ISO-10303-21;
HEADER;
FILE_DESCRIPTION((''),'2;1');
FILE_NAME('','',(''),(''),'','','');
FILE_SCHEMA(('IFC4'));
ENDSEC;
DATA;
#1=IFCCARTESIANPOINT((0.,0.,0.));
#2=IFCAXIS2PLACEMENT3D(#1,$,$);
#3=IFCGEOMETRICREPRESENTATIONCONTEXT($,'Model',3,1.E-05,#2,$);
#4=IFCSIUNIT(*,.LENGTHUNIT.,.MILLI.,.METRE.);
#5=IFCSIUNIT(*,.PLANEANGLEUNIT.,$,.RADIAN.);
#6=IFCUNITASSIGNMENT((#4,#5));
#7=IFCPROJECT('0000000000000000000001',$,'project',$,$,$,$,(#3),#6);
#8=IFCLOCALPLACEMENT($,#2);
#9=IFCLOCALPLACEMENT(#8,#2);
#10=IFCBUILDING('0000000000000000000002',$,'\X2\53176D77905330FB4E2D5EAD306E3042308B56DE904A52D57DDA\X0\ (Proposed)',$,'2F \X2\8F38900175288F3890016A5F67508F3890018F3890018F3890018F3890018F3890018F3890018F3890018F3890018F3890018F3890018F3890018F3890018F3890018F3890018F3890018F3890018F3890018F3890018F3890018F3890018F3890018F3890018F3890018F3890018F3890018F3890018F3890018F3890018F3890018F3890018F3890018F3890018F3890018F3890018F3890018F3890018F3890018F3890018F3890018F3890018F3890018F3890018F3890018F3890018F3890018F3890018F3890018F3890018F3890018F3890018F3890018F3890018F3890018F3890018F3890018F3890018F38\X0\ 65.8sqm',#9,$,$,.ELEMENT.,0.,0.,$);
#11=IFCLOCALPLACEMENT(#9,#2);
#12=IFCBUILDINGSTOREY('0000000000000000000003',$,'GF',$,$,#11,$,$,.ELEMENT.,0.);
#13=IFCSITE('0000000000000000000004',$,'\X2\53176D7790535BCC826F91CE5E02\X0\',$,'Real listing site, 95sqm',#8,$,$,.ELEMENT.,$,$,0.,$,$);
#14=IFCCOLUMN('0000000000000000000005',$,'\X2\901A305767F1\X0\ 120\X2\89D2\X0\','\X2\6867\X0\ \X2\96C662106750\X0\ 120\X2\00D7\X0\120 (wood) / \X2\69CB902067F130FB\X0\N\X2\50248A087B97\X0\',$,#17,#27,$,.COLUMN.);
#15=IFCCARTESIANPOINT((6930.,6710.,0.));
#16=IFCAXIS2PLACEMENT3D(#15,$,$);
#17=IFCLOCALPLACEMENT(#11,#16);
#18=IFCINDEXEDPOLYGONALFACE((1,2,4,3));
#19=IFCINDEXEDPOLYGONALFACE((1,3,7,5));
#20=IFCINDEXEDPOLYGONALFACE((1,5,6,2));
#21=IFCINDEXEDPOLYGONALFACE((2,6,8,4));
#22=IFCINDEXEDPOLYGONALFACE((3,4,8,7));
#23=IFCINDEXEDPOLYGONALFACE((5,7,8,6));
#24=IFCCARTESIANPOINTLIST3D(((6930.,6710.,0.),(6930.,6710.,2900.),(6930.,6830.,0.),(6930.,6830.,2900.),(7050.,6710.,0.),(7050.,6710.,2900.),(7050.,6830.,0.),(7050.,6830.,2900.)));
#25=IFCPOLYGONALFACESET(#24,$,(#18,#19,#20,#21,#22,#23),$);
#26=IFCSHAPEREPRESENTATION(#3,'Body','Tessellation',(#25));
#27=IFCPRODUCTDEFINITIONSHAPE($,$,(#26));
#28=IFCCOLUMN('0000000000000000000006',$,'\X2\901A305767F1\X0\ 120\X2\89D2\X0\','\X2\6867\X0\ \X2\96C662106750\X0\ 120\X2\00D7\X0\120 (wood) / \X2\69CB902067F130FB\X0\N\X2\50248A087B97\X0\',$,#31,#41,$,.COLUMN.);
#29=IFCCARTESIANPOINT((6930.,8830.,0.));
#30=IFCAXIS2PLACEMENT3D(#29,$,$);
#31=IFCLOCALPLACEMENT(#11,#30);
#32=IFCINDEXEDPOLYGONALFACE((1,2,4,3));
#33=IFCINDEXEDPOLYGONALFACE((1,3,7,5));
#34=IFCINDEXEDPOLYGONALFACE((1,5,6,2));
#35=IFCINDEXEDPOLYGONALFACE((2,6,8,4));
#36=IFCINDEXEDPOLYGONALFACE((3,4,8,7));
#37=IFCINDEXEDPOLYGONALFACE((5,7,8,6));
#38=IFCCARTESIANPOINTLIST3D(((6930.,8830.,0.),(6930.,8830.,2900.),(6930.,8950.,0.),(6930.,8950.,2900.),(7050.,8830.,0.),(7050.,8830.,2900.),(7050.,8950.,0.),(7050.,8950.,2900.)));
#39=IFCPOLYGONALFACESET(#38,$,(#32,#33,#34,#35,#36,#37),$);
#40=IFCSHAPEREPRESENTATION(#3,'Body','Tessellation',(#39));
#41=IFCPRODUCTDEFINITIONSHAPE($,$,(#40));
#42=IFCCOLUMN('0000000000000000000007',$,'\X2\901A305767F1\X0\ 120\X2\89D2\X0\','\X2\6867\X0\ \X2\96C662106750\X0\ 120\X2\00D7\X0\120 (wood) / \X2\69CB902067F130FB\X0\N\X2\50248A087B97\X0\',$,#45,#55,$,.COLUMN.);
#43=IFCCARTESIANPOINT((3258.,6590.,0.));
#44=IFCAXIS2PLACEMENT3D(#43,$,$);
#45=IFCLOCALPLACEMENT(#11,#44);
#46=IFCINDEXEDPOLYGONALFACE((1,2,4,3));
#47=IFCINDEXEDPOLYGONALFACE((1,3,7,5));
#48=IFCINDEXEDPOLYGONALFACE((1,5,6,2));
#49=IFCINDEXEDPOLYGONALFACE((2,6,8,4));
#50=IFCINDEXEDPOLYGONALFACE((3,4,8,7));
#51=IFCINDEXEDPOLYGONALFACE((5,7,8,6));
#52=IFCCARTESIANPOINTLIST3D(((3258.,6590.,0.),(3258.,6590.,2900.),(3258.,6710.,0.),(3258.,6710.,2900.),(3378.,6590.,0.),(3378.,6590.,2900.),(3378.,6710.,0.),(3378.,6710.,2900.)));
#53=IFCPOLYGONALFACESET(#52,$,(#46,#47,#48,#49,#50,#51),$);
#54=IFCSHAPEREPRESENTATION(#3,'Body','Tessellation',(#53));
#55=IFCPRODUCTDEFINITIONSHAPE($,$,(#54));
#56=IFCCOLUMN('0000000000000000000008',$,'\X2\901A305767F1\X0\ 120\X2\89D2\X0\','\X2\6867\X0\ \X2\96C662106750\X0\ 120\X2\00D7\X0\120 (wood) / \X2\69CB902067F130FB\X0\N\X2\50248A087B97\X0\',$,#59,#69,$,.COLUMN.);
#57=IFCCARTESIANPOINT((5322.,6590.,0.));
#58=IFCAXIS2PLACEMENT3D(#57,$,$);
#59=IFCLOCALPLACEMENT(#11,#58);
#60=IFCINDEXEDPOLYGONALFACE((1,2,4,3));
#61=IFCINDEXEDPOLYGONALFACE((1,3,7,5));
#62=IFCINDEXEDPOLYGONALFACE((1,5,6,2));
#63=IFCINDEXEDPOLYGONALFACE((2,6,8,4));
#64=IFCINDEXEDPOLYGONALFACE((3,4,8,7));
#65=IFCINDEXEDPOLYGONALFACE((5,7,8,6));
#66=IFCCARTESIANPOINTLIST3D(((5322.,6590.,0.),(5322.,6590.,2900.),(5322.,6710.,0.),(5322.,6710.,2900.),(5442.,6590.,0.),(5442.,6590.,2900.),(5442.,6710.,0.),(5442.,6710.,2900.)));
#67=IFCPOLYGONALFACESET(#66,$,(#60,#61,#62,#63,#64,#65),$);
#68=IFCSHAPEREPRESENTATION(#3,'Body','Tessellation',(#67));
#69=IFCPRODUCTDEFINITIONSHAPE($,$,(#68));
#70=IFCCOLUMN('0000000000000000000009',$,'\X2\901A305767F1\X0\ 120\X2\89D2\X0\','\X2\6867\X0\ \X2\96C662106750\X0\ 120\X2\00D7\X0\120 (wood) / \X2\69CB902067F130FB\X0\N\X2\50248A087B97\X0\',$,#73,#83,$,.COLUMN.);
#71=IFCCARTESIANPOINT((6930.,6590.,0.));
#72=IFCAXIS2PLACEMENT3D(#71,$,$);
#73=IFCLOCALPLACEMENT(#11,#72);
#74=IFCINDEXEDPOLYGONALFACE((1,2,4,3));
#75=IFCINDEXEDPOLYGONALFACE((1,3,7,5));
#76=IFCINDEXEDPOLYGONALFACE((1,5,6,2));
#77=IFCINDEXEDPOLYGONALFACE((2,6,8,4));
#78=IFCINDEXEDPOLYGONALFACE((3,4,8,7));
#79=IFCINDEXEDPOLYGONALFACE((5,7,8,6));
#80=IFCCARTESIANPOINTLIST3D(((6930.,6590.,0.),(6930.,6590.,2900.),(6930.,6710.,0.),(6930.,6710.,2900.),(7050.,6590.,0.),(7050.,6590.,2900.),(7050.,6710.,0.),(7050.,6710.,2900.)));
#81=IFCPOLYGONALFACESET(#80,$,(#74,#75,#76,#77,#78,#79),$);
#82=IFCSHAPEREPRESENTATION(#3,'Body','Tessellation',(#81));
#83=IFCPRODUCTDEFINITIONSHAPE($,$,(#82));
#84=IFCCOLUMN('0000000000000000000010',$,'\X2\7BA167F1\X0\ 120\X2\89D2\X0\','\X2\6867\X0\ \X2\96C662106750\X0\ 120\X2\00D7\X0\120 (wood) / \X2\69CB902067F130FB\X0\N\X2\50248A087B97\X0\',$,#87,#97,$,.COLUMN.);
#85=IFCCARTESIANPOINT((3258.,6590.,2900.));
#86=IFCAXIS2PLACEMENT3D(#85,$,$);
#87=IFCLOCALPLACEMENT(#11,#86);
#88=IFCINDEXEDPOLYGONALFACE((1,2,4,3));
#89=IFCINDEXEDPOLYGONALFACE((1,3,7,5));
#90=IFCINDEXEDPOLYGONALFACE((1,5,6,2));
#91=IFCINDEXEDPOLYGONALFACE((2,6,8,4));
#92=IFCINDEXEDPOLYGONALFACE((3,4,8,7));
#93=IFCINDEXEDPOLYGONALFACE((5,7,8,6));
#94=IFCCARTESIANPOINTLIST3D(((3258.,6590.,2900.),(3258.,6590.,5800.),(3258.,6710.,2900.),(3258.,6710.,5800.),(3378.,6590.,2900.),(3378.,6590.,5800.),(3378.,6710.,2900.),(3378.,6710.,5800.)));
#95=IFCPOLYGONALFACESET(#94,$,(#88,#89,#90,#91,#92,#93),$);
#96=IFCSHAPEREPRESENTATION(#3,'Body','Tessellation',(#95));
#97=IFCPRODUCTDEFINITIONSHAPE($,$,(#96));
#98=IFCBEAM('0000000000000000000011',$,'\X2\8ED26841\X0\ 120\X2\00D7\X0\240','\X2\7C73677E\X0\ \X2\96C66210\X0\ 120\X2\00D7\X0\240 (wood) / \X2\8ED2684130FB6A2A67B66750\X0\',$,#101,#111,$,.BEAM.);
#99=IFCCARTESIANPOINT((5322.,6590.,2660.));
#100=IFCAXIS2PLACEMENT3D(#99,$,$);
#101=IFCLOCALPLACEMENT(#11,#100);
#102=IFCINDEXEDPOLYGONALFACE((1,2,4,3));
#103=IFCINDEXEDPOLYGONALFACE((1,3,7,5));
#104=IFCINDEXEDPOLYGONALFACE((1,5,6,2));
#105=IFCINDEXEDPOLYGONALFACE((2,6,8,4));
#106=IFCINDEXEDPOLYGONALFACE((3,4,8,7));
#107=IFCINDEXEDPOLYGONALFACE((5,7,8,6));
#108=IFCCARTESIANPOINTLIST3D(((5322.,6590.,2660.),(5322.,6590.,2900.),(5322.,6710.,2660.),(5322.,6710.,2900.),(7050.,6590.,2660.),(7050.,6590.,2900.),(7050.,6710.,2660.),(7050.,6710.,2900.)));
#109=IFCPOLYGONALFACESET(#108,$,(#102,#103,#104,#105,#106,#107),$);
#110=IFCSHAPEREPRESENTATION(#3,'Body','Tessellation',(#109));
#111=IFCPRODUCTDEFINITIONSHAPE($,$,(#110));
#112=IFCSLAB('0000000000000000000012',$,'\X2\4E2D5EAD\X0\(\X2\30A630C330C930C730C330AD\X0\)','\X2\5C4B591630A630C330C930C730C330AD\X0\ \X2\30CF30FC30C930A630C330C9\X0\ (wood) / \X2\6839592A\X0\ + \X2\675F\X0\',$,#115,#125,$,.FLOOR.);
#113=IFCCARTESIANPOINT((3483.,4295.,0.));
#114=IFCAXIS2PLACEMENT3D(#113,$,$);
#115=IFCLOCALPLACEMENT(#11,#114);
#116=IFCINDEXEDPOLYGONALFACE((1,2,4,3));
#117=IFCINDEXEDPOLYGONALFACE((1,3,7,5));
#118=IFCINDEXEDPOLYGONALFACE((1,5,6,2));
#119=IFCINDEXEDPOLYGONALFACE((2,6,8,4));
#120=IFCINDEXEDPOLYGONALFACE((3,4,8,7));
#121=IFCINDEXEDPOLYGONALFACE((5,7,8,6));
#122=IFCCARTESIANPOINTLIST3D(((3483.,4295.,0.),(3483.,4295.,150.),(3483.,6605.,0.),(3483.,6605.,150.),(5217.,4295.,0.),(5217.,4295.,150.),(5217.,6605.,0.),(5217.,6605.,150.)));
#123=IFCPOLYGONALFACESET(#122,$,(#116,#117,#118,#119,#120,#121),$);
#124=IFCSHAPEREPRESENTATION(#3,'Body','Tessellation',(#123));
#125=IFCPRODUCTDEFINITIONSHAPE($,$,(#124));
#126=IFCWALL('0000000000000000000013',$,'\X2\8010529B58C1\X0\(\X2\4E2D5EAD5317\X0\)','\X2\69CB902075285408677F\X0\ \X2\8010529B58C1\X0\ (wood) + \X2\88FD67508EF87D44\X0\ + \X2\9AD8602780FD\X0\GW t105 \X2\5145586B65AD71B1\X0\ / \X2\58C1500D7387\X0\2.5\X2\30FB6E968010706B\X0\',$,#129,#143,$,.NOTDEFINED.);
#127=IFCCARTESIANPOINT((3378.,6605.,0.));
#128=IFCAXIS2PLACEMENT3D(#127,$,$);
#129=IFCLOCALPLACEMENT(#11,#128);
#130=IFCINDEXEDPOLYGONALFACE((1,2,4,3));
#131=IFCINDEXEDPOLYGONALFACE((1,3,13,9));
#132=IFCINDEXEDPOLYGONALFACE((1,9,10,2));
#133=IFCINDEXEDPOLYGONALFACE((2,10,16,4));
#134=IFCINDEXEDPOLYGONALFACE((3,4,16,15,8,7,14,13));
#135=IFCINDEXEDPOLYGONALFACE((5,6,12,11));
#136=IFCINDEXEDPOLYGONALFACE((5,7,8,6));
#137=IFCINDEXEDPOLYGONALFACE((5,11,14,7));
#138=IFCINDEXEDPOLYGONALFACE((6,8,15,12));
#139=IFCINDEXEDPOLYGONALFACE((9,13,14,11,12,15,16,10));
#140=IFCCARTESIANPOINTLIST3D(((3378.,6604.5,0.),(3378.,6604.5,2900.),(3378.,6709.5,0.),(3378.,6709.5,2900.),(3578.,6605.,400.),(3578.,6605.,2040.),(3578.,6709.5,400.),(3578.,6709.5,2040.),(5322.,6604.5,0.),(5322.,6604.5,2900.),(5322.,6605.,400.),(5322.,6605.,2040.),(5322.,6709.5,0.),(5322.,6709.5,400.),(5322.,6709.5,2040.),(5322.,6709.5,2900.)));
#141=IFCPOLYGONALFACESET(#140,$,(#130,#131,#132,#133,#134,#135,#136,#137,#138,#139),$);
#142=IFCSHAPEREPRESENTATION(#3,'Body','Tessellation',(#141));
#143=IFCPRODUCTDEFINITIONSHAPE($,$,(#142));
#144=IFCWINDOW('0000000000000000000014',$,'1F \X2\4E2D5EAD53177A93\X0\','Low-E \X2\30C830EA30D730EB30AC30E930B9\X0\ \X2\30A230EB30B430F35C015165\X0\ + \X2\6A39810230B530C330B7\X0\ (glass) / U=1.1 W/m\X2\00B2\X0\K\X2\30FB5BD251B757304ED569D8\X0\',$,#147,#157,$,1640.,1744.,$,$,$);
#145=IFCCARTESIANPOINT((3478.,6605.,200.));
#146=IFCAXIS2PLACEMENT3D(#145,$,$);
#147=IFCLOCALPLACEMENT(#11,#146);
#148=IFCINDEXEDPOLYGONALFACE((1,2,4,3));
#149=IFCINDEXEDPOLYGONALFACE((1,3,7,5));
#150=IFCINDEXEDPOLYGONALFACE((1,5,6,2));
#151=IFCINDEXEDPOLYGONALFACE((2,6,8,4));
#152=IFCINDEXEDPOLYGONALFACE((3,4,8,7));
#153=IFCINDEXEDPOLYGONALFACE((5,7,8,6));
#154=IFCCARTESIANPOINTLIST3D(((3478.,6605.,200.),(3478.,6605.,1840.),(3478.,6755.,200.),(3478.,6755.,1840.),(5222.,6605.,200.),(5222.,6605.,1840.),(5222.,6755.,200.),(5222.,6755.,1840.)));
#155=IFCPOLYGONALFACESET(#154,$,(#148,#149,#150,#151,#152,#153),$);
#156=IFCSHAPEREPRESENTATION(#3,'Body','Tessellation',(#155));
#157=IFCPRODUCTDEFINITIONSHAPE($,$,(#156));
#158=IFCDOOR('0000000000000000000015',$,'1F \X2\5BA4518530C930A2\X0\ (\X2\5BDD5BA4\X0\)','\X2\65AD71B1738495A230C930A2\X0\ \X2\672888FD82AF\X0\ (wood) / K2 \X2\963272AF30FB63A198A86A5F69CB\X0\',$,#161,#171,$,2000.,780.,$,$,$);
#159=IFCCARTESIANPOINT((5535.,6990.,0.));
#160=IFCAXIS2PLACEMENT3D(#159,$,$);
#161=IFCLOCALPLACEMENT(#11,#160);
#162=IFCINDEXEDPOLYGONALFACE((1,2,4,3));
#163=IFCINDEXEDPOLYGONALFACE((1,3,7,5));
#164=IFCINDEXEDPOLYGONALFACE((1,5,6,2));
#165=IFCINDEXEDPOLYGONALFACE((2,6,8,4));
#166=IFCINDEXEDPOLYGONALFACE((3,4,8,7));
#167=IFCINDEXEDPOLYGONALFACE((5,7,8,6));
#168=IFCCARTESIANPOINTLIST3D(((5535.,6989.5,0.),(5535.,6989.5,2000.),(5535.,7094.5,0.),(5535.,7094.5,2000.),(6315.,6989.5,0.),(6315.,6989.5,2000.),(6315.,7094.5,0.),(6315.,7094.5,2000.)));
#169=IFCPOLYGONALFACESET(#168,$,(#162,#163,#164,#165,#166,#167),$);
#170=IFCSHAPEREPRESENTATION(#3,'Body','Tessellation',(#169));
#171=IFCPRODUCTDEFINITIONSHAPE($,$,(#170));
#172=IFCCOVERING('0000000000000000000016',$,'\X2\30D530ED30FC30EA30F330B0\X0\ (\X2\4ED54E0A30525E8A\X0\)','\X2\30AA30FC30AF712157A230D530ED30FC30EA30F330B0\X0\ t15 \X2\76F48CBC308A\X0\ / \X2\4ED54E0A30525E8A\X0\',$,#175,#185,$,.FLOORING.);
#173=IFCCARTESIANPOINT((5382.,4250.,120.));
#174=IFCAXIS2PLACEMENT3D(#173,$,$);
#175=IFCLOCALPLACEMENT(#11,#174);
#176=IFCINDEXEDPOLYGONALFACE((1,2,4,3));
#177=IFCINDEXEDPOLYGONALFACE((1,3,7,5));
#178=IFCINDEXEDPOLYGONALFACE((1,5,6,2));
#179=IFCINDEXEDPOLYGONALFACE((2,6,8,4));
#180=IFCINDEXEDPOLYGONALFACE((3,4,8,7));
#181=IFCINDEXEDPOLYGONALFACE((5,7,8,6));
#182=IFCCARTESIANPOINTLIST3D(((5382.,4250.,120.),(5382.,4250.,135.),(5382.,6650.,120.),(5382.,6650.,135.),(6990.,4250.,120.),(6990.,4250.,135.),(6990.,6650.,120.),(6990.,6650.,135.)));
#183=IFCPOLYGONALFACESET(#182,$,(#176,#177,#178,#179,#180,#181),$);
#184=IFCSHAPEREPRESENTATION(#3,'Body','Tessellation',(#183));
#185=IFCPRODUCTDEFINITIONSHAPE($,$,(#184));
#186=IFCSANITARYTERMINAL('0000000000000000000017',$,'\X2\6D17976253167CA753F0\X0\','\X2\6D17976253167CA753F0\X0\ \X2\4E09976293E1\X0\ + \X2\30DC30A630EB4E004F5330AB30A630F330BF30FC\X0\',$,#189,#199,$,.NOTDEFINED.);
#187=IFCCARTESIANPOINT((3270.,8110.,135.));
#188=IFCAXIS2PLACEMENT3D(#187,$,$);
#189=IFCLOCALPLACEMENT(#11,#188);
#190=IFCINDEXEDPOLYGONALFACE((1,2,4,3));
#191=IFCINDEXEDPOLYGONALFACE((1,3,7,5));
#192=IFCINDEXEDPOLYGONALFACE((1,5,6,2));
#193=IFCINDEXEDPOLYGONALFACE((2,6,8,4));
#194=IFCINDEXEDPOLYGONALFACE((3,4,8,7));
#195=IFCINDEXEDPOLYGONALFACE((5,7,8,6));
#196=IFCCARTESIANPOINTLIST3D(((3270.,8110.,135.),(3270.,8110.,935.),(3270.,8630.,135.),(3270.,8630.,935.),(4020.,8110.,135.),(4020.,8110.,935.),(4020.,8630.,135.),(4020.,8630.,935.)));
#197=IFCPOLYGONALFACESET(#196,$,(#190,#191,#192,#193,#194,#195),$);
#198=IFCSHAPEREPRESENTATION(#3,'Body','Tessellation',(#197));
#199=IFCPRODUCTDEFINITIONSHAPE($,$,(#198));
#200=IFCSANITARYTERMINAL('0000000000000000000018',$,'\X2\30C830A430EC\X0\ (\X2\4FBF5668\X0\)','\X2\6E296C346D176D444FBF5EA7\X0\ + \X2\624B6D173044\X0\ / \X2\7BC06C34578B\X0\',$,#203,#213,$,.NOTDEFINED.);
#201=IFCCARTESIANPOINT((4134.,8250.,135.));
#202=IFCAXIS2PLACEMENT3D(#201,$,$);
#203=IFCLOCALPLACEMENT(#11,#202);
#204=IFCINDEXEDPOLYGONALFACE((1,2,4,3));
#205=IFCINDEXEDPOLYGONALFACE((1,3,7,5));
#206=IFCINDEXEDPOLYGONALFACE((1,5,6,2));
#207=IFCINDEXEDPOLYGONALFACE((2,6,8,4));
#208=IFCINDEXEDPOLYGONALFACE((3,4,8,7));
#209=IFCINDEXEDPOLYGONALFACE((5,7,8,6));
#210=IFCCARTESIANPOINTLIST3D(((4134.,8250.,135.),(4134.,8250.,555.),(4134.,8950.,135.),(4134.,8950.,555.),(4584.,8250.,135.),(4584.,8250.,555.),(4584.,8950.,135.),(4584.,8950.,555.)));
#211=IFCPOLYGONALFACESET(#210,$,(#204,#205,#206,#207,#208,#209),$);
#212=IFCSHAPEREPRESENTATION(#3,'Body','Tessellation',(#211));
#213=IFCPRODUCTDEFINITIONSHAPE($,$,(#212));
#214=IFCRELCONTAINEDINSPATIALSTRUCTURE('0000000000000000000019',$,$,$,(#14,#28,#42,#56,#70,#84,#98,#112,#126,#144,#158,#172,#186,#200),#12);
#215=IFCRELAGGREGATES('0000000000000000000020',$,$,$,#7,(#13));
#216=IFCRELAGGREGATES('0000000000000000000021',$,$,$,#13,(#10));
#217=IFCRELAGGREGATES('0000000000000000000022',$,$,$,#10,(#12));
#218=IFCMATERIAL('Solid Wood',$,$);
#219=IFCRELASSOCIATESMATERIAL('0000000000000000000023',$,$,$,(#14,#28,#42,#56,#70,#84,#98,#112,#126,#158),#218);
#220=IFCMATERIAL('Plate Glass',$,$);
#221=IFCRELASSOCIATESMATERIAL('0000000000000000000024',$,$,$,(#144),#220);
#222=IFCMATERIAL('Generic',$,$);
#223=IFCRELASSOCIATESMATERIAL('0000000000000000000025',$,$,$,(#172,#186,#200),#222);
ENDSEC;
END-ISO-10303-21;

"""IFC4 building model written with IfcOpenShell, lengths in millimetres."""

from ifc_helpers import new_model, si_unit, frame, frame_2d, origin, place, context, project, spatial, rectangle, extrude, material, element, fill, save


model = new_model("IFC4")

# Units and contexts
model_context = context("Model", 3, precision=1e-05, world=origin())
ifc_project = project(units=[si_unit("LENGTHUNIT", "METRE", prefix="MILLI"), si_unit("PLANEANGLEUNIT", "RADIAN")], contexts=[model_context])

# Site, building, storey
site_placement = place(None, origin())
site = spatial("IfcSite", under=ifc_project, at=site_placement, Name="北海道富良野市", ObjectType="Real listing site, 95sqm", CompositionType="ELEMENT", RefElevation=0.0)
building_placement = place(site_placement, origin())
building = spatial("IfcBuilding", under=site, at=building_placement, Name="北海道・中庭のある回遊動線 (Proposed)", ObjectType="2F 輸送用輸送機材輸送輸送輸送輸送輸送輸送輸送輸送輸送輸送輸送輸送輸送輸送輸送輸送輸送輸送輸送輸送輸送輸送輸送輸送輸送輸送輸送輸送輸送輸送輸送輸送輸送輸送輸送輸送輸送輸送輸送輸送輸送輸送輸送輸送輸送輸送輸送輸送輸送輸送輸送輸送輸送輸送輸送輸送輸 65.8sqm", CompositionType="ELEMENT", ElevationOfRefHeight=0.0, ElevationOfTerrain=0.0)
storey_placement = place(building_placement, origin())
storey = spatial("IfcBuildingStorey", under=building, at=storey_placement, Name="GF", CompositionType="ELEMENT", Elevation=0.0)

# Columns
ifc_material_1 = material(Name="Solid Wood")
column_1_placement = place(storey_placement, frame((6930.0, 6710.0, 0.0)))
element("IfcColumn", 1, at=column_1_placement, inside=storey, material=ifc_material_1, Name="通し柱 120角", Description="桧 集成材 120×120 (wood) / 構造柱・N値計算", PredefinedType="COLUMN", context=model_context, shape_type="SweptSolid", body=[
    extrude(rectangle(XDim=120.0, YDim=120.0, at=frame_2d((60.0, 60.0))), frame((6930.0, 6710.0, 0.0)), (0.0, 0.0, 1.0), 2900.0),
])
column_2_placement = place(storey_placement, frame((6930.0, 8830.0, 0.0)))
element("IfcColumn", 2, at=column_2_placement, inside=storey, material=ifc_material_1, Name="通し柱 120角", Description="桧 集成材 120×120 (wood) / 構造柱・N値計算", PredefinedType="COLUMN", context=model_context, shape_type="SweptSolid", body=[
    extrude(rectangle(XDim=120.0, YDim=120.0, at=frame_2d((60.0, 60.0))), frame((6930.0, 8830.0, 0.0)), (0.0, 0.0, 1.0), 2900.0),
])
column_3_placement = place(storey_placement, frame((3258.0, 6590.0, 0.0)))
element("IfcColumn", 3, at=column_3_placement, inside=storey, material=ifc_material_1, Name="通し柱 120角", Description="桧 集成材 120×120 (wood) / 構造柱・N値計算", PredefinedType="COLUMN", context=model_context, shape_type="SweptSolid", body=[
    extrude(rectangle(XDim=120.0, YDim=120.0, at=frame_2d((60.0, 60.0))), frame((3258.0, 6590.0, 0.0)), (0.0, 0.0, 1.0), 2900.0),
])
column_4_placement = place(storey_placement, frame((5322.0, 6590.0, 0.0)))
element("IfcColumn", 4, at=column_4_placement, inside=storey, material=ifc_material_1, Name="通し柱 120角", Description="桧 集成材 120×120 (wood) / 構造柱・N値計算", PredefinedType="COLUMN", context=model_context, shape_type="SweptSolid", body=[
    extrude(rectangle(XDim=120.0, YDim=120.0, at=frame_2d((60.0, 60.0))), frame((5322.0, 6590.0, 0.0)), (0.0, 0.0, 1.0), 2900.0),
])
column_5_placement = place(storey_placement, frame((6930.0, 6590.0, 0.0)))
element("IfcColumn", 5, at=column_5_placement, inside=storey, material=ifc_material_1, Name="通し柱 120角", Description="桧 集成材 120×120 (wood) / 構造柱・N値計算", PredefinedType="COLUMN", context=model_context, shape_type="SweptSolid", body=[
    extrude(rectangle(XDim=120.0, YDim=120.0, at=frame_2d((60.0, 60.0))), frame((6930.0, 6590.0, 0.0)), (0.0, 0.0, 1.0), 2900.0),
])
column_6_placement = place(storey_placement, frame((3258.0, 6590.0, 2900.0)))
element("IfcColumn", 6, at=column_6_placement, inside=storey, material=ifc_material_1, Name="管柱 120角", Description="桧 集成材 120×120 (wood) / 構造柱・N値計算", PredefinedType="COLUMN", context=model_context, shape_type="SweptSolid", body=[
    extrude(rectangle(XDim=120.0, YDim=120.0, at=frame_2d((60.0, 60.0))), frame((3258.0, 6590.0, 2900.0)), (0.0, 0.0, 1.0), 2900.0),
])

# Beam
beam_1_placement = place(storey_placement, frame((5322.0, 6590.0, 2660.0)))
element("IfcBeam", 7, at=beam_1_placement, inside=storey, material=ifc_material_1, Name="軒桁 120×240", Description="米松 集成 120×240 (wood) / 軒桁・横架材", PredefinedType="BEAM", context=model_context, shape_type="SweptSolid", body=[
    extrude(rectangle(XDim=1728.0, YDim=120.0, at=frame_2d((864.0, 60.0))), frame((5322.0, 6590.0, 2660.0)), (0.0, 0.0, 1.0), 240.0),
])

# Slab
slab_placement = place(storey_placement, frame((3483.0, 4295.0, 0.0)))
element("IfcSlab", 8, at=slab_placement, inside=storey, material=ifc_material_1, Name="中庭(ウッドデッキ)", Description="屋外ウッドデッキ ハードウッド (wood) / 根太 + 束", PredefinedType="FLOOR", context=model_context, shape_type="SweptSolid", body=[
    extrude(rectangle(XDim=1734.0, YDim=2310.0, at=frame_2d((867.0, 1155.0))), frame((3483.0, 4295.0, 0.0)), (0.0, 0.0, 1.0), 150.0),
])

# Wall, opening, window
wall_1_placement = place(storey_placement, frame((3378.0, 6605.0, 0.0)))
wall_1 = element("IfcWall", 9, at=wall_1_placement, inside=storey, material=ifc_material_1, Name="耐力壁(中庭北)", Description="構造用合板 耐力壁 (wood) + 製材軸組 + 高性能GW t105 充填断熱 / 壁倍率2.5・準耐火", PredefinedType="NOTDEFINED", context=model_context, shape_type="SweptSolid", body=[
    extrude(rectangle(XDim=1944.0, YDim=105.0, at=frame_2d((972.0, 52.0))), frame((3378.0, 6605.0, 0.0)), (0.0, 0.0, 1.0), 2900.0),
])
opening_placement = place(storey_placement, frame((3478.0, 6605.0, 200.0)))
opening = element("IfcOpeningElement", 10, at=opening_placement, cuts=wall_1, PredefinedType="NOTDEFINED", context=model_context, shape_type="SweptSolid", body=[
    extrude(rectangle(XDim=1744.0, YDim=150.0, at=frame_2d((872.0, 75.0))), frame((3478.0, 6605.0, 200.0)), (0.0, 0.0, 1.0), 1640.0),
])
ifc_material_2 = material(Name="Plate Glass")
window_placement = place(storey_placement, frame((3478.0, 6605.0, 200.0)))
window = element("IfcWindow", 11, at=window_placement, inside=storey, material=ifc_material_2, Name="1F 中庭北窓", Description="Low-E トリプルガラス アルゴン封入 + 樹脂サッシ (glass) / U=1.1 W/m²K・寒冷地仕様", OverallHeight=1640.0, OverallWidth=1744.0, context=model_context, shape_type="SweptSolid", body=[
    extrude(rectangle(XDim=1744.0, YDim=150.0, at=frame_2d((872.0, 75.0))), frame((3478.0, 6605.0, 200.0)), (0.0, 0.0, 1.0), 1640.0),
])
fill(opening, window)

# Door
door_placement = place(storey_placement, frame((5535.0, 6990.0, 0.0)))
element("IfcDoor", 12, at=door_placement, inside=storey, material=ifc_material_1, Name="1F 室内ドア (寝室)", Description="断熱玄関ドア 木製芯 (wood) / K2 防犯・採風機構", OverallHeight=2000.0, OverallWidth=780.0, context=model_context, shape_type="SweptSolid", body=[
    extrude(rectangle(XDim=780.0, YDim=105.0, at=frame_2d((390.0, 52.0))), frame((5535.0, 6990.0, 0.0)), (0.0, 0.0, 1.0), 2000.0),
])

# Covering
ifc_material_3 = material(Name="Generic")
covering_placement = place(storey_placement, frame((5382.0, 4250.0, 120.0)))
element("IfcCovering", 13, at=covering_placement, inside=storey, material=ifc_material_3, Name="フローリング (仕上げ床)", Description="オーク無垢フローリング t15 直貼り / 仕上げ床", PredefinedType="FLOORING", context=model_context, shape_type="SweptSolid", body=[
    extrude(rectangle(XDim=1608.0, YDim=2400.0, at=frame_2d((804.0, 1200.0))), frame((5382.0, 4250.0, 120.0)), (0.0, 0.0, 1.0), 15.0),
])

# Sanitary terminals
sanitary_terminal_1_placement = place(storey_placement, frame((3270.0, 8110.0, 135.0)))
element("IfcSanitaryTerminal", 14, at=sanitary_terminal_1_placement, inside=storey, material=ifc_material_3, Name="洗面化粧台", Description="洗面化粧台 三面鏡 + ボウル一体カウンター", PredefinedType="NOTDEFINED", context=model_context, shape_type="SweptSolid", body=[
    extrude(rectangle(XDim=750.0, YDim=520.0, at=frame_2d((375.0, 260.0))), frame((3270.0, 8110.0, 135.0)), (0.0, 0.0, 1.0), 800.0),
])
sanitary_terminal_2_placement = place(storey_placement, frame((4134.0, 8250.0, 135.0)))
element("IfcSanitaryTerminal", 15, at=sanitary_terminal_2_placement, inside=storey, material=ifc_material_3, Name="トイレ (便器)", Description="温水洗浄便座 + 手洗い / 節水型", PredefinedType="NOTDEFINED", context=model_context, shape_type="SweptSolid", body=[
    extrude(rectangle(XDim=450.0, YDim=700.0, at=frame_2d((225.0, 350.0))), frame((4134.0, 8250.0, 135.0)), (0.0, 0.0, 1.0), 420.0),
])

save(model, "model.ifc")
